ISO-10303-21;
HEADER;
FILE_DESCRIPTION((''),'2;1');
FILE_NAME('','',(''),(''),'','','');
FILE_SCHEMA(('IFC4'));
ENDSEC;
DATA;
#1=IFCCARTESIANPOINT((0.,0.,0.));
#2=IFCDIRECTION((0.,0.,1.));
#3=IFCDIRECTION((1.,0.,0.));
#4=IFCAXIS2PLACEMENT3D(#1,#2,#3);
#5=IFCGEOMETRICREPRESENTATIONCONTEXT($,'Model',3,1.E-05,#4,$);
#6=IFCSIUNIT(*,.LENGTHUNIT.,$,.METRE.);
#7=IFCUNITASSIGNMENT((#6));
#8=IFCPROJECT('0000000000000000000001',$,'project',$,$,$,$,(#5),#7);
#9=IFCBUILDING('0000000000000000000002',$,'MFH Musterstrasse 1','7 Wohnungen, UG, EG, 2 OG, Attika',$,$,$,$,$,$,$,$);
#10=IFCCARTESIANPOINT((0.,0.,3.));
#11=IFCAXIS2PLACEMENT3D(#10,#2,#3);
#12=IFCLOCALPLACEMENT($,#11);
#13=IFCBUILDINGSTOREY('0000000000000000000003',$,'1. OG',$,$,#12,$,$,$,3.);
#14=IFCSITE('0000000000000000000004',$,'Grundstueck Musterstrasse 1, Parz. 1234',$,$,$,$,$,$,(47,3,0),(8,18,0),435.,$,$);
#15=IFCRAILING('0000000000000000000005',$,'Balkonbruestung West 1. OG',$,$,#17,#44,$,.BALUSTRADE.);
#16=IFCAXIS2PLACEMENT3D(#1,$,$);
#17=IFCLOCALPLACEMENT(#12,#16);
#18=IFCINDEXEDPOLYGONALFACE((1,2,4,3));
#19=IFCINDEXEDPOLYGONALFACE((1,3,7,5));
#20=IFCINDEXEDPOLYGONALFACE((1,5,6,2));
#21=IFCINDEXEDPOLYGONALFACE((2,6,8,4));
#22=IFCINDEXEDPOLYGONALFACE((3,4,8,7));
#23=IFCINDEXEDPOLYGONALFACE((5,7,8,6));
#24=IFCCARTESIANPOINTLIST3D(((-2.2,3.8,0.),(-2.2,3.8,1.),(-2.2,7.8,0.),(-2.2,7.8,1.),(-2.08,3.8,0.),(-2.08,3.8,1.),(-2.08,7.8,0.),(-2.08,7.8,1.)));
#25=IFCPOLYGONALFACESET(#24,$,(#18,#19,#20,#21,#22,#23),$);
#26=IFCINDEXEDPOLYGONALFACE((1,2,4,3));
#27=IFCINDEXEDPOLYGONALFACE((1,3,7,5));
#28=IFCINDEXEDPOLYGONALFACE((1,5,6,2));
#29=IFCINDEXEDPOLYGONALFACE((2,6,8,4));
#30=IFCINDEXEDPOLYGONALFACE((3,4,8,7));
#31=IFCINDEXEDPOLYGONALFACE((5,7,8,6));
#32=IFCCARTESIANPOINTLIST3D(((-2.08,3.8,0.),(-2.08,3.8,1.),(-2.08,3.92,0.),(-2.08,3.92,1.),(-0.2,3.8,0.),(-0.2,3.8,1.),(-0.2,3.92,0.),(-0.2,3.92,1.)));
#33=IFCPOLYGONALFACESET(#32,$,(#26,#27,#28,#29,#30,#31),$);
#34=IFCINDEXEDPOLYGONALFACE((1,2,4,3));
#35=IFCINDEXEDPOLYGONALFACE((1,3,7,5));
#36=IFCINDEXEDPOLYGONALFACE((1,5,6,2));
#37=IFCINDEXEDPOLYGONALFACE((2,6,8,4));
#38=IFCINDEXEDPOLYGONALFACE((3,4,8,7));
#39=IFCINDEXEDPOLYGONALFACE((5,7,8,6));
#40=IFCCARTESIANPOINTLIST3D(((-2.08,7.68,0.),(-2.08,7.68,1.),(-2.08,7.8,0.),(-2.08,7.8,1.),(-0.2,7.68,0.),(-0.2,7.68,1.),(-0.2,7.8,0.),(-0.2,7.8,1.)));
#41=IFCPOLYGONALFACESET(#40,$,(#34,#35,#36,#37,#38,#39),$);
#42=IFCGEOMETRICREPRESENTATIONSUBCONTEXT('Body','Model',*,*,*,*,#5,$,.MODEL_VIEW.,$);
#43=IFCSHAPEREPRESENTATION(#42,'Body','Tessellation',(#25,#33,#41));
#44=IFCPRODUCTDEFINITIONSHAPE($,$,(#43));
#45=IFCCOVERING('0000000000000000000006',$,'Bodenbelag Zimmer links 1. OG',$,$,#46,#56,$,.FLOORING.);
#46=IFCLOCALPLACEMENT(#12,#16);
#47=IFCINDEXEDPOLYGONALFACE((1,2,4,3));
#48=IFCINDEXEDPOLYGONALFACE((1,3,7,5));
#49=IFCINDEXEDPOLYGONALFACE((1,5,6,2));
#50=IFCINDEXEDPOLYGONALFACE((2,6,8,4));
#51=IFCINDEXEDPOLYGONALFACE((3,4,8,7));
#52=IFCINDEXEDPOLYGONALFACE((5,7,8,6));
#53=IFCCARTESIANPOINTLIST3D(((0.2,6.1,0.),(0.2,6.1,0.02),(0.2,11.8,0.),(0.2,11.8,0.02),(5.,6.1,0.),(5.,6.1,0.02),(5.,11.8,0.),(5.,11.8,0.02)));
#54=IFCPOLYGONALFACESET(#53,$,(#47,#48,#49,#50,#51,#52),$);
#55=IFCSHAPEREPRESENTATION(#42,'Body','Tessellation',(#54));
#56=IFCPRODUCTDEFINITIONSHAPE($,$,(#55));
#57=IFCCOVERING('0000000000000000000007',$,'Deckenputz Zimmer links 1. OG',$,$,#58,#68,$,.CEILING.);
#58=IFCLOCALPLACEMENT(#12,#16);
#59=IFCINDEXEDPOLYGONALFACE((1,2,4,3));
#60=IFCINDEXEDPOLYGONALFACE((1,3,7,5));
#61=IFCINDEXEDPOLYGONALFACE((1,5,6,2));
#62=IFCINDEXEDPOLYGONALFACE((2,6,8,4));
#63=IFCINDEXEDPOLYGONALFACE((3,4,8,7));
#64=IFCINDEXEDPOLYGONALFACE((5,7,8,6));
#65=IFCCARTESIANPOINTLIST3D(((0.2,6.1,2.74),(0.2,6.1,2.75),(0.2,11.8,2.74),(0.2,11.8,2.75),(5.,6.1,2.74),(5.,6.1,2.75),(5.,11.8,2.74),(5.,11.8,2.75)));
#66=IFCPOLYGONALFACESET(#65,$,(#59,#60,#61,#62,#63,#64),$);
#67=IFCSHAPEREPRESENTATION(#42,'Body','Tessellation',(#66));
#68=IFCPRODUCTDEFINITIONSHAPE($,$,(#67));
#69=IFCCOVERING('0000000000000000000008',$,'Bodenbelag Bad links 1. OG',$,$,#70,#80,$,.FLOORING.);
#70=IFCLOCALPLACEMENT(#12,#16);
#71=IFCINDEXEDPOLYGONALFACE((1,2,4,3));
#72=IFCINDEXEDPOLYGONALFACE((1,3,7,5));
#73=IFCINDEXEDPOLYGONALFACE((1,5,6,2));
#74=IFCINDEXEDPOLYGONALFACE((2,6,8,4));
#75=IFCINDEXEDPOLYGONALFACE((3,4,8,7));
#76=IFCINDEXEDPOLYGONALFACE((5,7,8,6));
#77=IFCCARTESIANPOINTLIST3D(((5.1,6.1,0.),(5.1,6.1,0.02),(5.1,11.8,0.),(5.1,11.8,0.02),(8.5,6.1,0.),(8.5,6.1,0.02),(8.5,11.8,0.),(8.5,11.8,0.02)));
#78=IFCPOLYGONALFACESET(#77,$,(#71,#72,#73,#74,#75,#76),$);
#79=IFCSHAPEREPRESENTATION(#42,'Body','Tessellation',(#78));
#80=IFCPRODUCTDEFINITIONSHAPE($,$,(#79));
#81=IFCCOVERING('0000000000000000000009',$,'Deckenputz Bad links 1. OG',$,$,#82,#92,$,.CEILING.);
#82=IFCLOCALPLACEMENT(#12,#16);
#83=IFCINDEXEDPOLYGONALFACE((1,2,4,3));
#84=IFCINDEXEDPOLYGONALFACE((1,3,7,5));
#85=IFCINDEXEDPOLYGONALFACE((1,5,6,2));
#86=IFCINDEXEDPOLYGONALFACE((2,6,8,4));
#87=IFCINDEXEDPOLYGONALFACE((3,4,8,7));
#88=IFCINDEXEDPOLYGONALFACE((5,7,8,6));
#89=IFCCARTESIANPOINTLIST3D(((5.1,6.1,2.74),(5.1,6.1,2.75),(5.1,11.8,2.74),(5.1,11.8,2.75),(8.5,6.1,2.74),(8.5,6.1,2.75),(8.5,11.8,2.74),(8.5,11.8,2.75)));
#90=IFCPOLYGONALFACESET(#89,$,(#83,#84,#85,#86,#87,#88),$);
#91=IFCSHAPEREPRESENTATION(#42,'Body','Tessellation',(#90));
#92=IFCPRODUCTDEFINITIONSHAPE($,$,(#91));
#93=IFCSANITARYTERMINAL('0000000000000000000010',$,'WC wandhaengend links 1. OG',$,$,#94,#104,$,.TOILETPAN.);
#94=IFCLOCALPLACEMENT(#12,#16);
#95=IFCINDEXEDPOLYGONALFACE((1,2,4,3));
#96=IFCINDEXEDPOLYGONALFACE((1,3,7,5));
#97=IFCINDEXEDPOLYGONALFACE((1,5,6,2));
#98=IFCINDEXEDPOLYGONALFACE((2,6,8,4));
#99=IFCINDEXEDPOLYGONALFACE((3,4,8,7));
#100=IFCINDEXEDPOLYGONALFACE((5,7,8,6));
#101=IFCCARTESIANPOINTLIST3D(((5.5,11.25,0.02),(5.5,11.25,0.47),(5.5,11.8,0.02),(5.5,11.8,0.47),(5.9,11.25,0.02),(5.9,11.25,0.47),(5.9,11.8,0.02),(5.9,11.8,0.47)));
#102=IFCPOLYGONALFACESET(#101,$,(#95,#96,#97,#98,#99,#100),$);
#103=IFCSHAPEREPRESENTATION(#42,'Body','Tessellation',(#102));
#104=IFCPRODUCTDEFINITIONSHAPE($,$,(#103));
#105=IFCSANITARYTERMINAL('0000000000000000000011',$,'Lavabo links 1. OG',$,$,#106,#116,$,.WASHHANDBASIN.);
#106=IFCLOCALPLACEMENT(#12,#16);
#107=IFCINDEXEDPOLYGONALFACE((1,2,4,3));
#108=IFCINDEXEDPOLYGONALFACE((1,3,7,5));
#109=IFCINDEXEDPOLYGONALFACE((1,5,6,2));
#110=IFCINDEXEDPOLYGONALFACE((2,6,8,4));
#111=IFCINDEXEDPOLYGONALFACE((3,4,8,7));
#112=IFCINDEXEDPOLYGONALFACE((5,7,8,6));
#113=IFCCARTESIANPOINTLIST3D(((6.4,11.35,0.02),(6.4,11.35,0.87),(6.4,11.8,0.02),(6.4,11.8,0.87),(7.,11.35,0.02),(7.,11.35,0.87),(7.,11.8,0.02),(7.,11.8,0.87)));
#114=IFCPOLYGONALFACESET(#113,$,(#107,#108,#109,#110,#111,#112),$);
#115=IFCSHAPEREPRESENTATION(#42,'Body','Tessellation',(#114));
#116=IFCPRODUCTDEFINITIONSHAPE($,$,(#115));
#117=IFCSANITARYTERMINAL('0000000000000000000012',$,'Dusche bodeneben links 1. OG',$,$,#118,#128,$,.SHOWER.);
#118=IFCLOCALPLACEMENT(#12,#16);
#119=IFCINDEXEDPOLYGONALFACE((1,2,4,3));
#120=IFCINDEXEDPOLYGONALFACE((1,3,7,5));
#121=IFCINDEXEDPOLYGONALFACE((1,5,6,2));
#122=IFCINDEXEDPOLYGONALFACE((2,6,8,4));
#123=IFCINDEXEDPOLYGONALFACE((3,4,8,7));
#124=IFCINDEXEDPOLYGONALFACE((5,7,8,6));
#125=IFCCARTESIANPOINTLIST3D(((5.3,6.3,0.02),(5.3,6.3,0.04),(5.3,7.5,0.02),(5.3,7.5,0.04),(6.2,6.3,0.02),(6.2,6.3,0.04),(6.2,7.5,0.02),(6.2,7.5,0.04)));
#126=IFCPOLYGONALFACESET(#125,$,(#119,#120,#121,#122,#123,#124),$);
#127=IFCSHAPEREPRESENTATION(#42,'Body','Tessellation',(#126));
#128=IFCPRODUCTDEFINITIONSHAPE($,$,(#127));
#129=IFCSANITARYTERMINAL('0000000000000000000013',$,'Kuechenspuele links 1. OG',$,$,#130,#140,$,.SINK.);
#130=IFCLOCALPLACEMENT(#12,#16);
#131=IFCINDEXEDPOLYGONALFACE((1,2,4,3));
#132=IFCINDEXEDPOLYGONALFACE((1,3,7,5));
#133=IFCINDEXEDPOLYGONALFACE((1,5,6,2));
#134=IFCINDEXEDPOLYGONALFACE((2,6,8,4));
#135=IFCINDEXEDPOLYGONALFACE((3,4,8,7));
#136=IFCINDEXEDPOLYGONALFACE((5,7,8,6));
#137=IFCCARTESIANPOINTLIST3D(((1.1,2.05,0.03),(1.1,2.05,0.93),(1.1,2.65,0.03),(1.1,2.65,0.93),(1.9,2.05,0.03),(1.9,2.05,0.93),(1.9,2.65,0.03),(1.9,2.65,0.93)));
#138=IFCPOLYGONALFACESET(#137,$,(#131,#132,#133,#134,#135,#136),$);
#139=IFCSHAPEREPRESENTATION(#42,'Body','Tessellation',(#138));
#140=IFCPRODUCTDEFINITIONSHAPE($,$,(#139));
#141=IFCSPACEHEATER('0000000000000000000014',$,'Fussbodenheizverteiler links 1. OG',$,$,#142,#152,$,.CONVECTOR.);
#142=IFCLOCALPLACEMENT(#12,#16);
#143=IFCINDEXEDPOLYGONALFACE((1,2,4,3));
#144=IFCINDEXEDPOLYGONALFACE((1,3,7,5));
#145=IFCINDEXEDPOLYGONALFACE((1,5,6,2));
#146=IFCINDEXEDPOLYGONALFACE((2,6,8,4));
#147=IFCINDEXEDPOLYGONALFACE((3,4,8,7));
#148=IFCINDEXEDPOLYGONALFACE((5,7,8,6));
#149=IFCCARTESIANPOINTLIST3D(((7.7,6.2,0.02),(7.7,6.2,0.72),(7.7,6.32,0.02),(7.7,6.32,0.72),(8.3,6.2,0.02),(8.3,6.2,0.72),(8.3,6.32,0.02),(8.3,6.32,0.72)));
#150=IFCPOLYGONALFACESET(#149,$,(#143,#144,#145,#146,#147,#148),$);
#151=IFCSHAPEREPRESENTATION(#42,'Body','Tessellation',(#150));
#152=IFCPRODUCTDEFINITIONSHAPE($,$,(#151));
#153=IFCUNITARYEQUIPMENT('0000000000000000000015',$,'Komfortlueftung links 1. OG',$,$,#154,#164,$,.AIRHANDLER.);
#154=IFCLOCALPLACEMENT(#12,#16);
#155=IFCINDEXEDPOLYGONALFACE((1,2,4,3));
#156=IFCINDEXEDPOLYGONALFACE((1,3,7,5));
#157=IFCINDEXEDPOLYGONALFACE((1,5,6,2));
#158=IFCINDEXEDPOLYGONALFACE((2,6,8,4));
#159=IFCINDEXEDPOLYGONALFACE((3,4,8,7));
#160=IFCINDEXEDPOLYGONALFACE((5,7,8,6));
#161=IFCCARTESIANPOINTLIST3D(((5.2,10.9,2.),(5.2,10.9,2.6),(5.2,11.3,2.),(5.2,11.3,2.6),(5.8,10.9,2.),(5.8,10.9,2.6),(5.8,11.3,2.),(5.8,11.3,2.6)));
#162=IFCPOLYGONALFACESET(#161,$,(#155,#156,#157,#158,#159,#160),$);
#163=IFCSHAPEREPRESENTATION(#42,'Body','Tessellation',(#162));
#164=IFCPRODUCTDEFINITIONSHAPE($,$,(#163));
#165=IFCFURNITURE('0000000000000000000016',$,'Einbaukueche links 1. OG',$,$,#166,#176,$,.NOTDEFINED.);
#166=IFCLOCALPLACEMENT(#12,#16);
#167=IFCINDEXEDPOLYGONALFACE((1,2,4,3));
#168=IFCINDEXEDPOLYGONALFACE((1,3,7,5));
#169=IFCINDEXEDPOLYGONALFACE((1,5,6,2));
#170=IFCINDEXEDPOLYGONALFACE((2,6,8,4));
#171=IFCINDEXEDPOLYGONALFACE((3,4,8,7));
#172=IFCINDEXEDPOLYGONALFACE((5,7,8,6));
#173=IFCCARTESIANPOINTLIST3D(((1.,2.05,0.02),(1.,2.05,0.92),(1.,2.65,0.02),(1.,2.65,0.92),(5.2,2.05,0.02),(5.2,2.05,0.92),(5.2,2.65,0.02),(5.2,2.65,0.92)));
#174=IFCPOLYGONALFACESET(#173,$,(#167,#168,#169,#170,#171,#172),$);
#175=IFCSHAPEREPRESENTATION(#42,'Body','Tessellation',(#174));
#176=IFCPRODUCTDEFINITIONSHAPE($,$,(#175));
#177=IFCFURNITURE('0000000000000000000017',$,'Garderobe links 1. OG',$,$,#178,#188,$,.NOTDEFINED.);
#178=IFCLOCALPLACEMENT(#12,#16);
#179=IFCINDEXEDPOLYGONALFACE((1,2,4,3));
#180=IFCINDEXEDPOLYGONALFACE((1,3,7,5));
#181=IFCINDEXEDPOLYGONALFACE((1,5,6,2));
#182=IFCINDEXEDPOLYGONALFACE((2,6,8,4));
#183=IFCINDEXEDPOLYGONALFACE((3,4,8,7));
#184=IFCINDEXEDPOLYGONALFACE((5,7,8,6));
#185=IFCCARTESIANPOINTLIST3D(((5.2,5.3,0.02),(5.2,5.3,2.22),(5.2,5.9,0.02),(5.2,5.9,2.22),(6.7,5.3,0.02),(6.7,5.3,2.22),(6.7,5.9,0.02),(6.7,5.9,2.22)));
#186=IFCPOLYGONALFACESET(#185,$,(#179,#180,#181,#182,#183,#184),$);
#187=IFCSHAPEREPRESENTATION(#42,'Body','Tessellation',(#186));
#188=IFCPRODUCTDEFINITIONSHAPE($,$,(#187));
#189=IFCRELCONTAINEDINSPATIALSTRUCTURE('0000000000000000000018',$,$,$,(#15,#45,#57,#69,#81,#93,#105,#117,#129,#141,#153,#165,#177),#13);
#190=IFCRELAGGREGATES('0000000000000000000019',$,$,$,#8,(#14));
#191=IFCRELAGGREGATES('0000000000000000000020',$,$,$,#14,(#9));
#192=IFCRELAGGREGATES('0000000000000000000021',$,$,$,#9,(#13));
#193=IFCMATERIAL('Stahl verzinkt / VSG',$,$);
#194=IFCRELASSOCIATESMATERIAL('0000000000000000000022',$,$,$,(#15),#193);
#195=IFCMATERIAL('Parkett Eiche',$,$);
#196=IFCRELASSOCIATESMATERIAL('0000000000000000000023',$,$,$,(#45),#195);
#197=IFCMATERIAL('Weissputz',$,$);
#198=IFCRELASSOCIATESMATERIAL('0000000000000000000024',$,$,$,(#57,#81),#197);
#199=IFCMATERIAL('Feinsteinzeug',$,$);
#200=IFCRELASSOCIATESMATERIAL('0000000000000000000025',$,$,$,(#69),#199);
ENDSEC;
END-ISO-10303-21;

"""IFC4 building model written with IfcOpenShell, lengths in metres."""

from ifc_helpers import new_model, si_unit, frame, frame_2d, origin_with_axes, place, context, subcontext, project, spatial, rectangle, extrude, material, element, save


model = new_model("IFC4")

# Units and contexts
model_context = context("Model", 3, precision=1e-05, world=origin_with_axes())
body_context = subcontext(model_context, "Body", "Model", "MODEL_VIEW")
ifc_project = project(units=[si_unit("LENGTHUNIT", "METRE")], contexts=[model_context])

# Site, building, storey
site = spatial("IfcSite", under=ifc_project, Name="Grundstueck Musterstrasse 1, Parz. 1234", RefLatitude=(47, 3, 0), RefLongitude=(8, 18, 0), RefElevation=435.0)
building = spatial("IfcBuilding", under=site, Name="MFH Musterstrasse 1", Description="7 Wohnungen, UG, EG, 2 OG, Attika")
storey_placement = place(None, frame((0.0, 0.0, 3.0), z_axis=(0.0, 0.0, 1.0), x_axis=(1.0, 0.0, 0.0)))
storey = spatial("IfcBuildingStorey", under=building, at=storey_placement, Name="1. OG", Elevation=3.0)

# Railing
ifc_material_1 = material(Name="Stahl verzinkt / VSG")
railing_placement = place(storey_placement, frame((-2.2, 3.8, 0.0), z_axis=(0.0, 0.0, 1.0), x_axis=(1.0, 0.0, 0.0)))
element("IfcRailing", 1, at=railing_placement, inside=storey, material=ifc_material_1, Name="Balkonbruestung West 1. OG", PredefinedType="BALUSTRADE", context=body_context, shape_type="SweptSolid", body=[
    extrude(rectangle(XDim=0.12, YDim=4.0, at=frame_2d((0.06, 2.0))), origin_with_axes(), (0.0, 0.0, 1.0), 1.0),
    extrude(rectangle(XDim=1.88, YDim=0.12, at=frame_2d((1.06, 0.06))), origin_with_axes(), (0.0, 0.0, 1.0), 1.0),
    extrude(rectangle(XDim=1.88, YDim=0.12, at=frame_2d((1.06, 3.94))), origin_with_axes(), (0.0, 0.0, 1.0), 1.0),
])

# Coverings
ifc_material_2 = material(Name="Parkett Eiche")
covering_1_placement = place(storey_placement, frame((0.2, 6.1, 0.0), z_axis=(0.0, 0.0, 1.0), x_axis=(1.0, 0.0, 0.0)))
element("IfcCovering", 2, at=covering_1_placement, inside=storey, material=ifc_material_2, Name="Bodenbelag Zimmer links 1. OG", PredefinedType="FLOORING", context=body_context, shape_type="SweptSolid", body=[
    extrude(rectangle(XDim=4.8, YDim=5.7, at=frame_2d((2.4, 2.85))), origin_with_axes(), (0.0, 0.0, 1.0), 0.02),
])
ifc_material_3 = material(Name="Weissputz")
covering_2_placement = place(storey_placement, frame((0.2, 6.1, 2.74), z_axis=(0.0, 0.0, 1.0), x_axis=(1.0, 0.0, 0.0)))
element("IfcCovering", 3, at=covering_2_placement, inside=storey, material=ifc_material_3, Name="Deckenputz Zimmer links 1. OG", PredefinedType="CEILING", context=body_context, shape_type="SweptSolid", body=[
    extrude(rectangle(XDim=4.8, YDim=5.7, at=frame_2d((2.4, 2.85))), origin_with_axes(), (0.0, 0.0, 1.0), 0.01),
])
ifc_material_4 = material(Name="Feinsteinzeug")
covering_3_placement = place(storey_placement, frame((5.1, 6.1, 0.0), z_axis=(0.0, 0.0, 1.0), x_axis=(1.0, 0.0, 0.0)))
element("IfcCovering", 4, at=covering_3_placement, inside=storey, material=ifc_material_4, Name="Bodenbelag Bad links 1. OG", PredefinedType="FLOORING", context=body_context, shape_type="SweptSolid", body=[
    extrude(rectangle(XDim=3.4, YDim=5.7, at=frame_2d((1.7, 2.85))), origin_with_axes(), (0.0, 0.0, 1.0), 0.02),
])
covering_4_placement = place(storey_placement, frame((5.1, 6.1, 2.74), z_axis=(0.0, 0.0, 1.0), x_axis=(1.0, 0.0, 0.0)))
element("IfcCovering", 5, at=covering_4_placement, inside=storey, material=ifc_material_3, Name="Deckenputz Bad links 1. OG", PredefinedType="CEILING", context=body_context, shape_type="SweptSolid", body=[
    extrude(rectangle(XDim=3.4, YDim=5.7, at=frame_2d((1.7, 2.85))), origin_with_axes(), (0.0, 0.0, 1.0), 0.01),
])

# Sanitary terminals
sanitary_terminal_1_placement = place(storey_placement, frame((5.5, 11.25, 0.02), z_axis=(0.0, 0.0, 1.0), x_axis=(1.0, 0.0, 0.0)))
element("IfcSanitaryTerminal", 6, at=sanitary_terminal_1_placement, inside=storey, Name="WC wandhaengend links 1. OG", PredefinedType="TOILETPAN", context=body_context, shape_type="SweptSolid", body=[
    extrude(rectangle(XDim=0.4, YDim=0.55, at=frame_2d((0.2, 0.275))), origin_with_axes(), (0.0, 0.0, 1.0), 0.45),
])
sanitary_terminal_2_placement = place(storey_placement, frame((6.4, 11.35, 0.02), z_axis=(0.0, 0.0, 1.0), x_axis=(1.0, 0.0, 0.0)))
element("IfcSanitaryTerminal", 7, at=sanitary_terminal_2_placement, inside=storey, Name="Lavabo links 1. OG", PredefinedType="WASHHANDBASIN", context=body_context, shape_type="SweptSolid", body=[
    extrude(rectangle(XDim=0.6, YDim=0.45, at=frame_2d((0.3, 0.225))), origin_with_axes(), (0.0, 0.0, 1.0), 0.85),
])
sanitary_terminal_3_placement = place(storey_placement, frame((5.3, 6.3, 0.02), z_axis=(0.0, 0.0, 1.0), x_axis=(1.0, 0.0, 0.0)))
element("IfcSanitaryTerminal", 8, at=sanitary_terminal_3_placement, inside=storey, Name="Dusche bodeneben links 1. OG", PredefinedType="SHOWER", context=body_context, shape_type="SweptSolid", body=[
    extrude(rectangle(XDim=0.9, YDim=1.2, at=frame_2d((0.45, 0.6))), origin_with_axes(), (0.0, 0.0, 1.0), 0.02),
])
sanitary_terminal_4_placement = place(storey_placement, frame((1.1, 2.05, 0.03), z_axis=(0.0, 0.0, 1.0), x_axis=(1.0, 0.0, 0.0)))
element("IfcSanitaryTerminal", 9, at=sanitary_terminal_4_placement, inside=storey, Name="Kuechenspuele links 1. OG", PredefinedType="SINK", context=body_context, shape_type="SweptSolid", body=[
    extrude(rectangle(XDim=0.8, YDim=0.6, at=frame_2d((0.4, 0.3))), origin_with_axes(), (0.0, 0.0, 1.0), 0.9),
])

# Space heater
space_heater_placement = place(storey_placement, frame((7.7, 6.2, 0.02), z_axis=(0.0, 0.0, 1.0), x_axis=(1.0, 0.0, 0.0)))
element("IfcSpaceHeater", 10, at=space_heater_placement, inside=storey, Name="Fussbodenheizverteiler links 1. OG", PredefinedType="CONVECTOR", context=body_context, shape_type="SweptSolid", body=[
    extrude(rectangle(XDim=0.6, YDim=0.12, at=frame_2d((0.3, 0.06))), origin_with_axes(), (0.0, 0.0, 1.0), 0.7),
])

# Unitary equipment
unitary_equipment_placement = place(storey_placement, frame((5.2, 10.9, 2.0), z_axis=(0.0, 0.0, 1.0), x_axis=(1.0, 0.0, 0.0)))
element("IfcUnitaryEquipment", 11, at=unitary_equipment_placement, inside=storey, Name="Komfortlueftung links 1. OG", PredefinedType="AIRHANDLER", context=body_context, shape_type="SweptSolid", body=[
    extrude(rectangle(XDim=0.6, YDim=0.4, at=frame_2d((0.3, 0.2))), origin_with_axes(), (0.0, 0.0, 1.0), 0.6),
])

# Furniture
furniture_1_placement = place(storey_placement, frame((1.0, 2.05, 0.02), z_axis=(0.0, 0.0, 1.0), x_axis=(1.0, 0.0, 0.0)))
element("IfcFurniture", 12, at=furniture_1_placement, inside=storey, Name="Einbaukueche links 1. OG", PredefinedType="NOTDEFINED", context=body_context, shape_type="SweptSolid", body=[
    extrude(rectangle(XDim=4.2, YDim=0.6, at=frame_2d((2.1, 0.3))), origin_with_axes(), (0.0, 0.0, 1.0), 0.9),
])
furniture_2_placement = place(storey_placement, frame((5.2, 5.3, 0.02), z_axis=(0.0, 0.0, 1.0), x_axis=(1.0, 0.0, 0.0)))
element("IfcFurniture", 13, at=furniture_2_placement, inside=storey, Name="Garderobe links 1. OG", PredefinedType="NOTDEFINED", context=body_context, shape_type="SweptSolid", body=[
    extrude(rectangle(XDim=1.5, YDim=0.6, at=frame_2d((0.75, 0.3))), origin_with_axes(), (0.0, 0.0, 1.0), 2.2),
])

save(model, "model.ifc")
